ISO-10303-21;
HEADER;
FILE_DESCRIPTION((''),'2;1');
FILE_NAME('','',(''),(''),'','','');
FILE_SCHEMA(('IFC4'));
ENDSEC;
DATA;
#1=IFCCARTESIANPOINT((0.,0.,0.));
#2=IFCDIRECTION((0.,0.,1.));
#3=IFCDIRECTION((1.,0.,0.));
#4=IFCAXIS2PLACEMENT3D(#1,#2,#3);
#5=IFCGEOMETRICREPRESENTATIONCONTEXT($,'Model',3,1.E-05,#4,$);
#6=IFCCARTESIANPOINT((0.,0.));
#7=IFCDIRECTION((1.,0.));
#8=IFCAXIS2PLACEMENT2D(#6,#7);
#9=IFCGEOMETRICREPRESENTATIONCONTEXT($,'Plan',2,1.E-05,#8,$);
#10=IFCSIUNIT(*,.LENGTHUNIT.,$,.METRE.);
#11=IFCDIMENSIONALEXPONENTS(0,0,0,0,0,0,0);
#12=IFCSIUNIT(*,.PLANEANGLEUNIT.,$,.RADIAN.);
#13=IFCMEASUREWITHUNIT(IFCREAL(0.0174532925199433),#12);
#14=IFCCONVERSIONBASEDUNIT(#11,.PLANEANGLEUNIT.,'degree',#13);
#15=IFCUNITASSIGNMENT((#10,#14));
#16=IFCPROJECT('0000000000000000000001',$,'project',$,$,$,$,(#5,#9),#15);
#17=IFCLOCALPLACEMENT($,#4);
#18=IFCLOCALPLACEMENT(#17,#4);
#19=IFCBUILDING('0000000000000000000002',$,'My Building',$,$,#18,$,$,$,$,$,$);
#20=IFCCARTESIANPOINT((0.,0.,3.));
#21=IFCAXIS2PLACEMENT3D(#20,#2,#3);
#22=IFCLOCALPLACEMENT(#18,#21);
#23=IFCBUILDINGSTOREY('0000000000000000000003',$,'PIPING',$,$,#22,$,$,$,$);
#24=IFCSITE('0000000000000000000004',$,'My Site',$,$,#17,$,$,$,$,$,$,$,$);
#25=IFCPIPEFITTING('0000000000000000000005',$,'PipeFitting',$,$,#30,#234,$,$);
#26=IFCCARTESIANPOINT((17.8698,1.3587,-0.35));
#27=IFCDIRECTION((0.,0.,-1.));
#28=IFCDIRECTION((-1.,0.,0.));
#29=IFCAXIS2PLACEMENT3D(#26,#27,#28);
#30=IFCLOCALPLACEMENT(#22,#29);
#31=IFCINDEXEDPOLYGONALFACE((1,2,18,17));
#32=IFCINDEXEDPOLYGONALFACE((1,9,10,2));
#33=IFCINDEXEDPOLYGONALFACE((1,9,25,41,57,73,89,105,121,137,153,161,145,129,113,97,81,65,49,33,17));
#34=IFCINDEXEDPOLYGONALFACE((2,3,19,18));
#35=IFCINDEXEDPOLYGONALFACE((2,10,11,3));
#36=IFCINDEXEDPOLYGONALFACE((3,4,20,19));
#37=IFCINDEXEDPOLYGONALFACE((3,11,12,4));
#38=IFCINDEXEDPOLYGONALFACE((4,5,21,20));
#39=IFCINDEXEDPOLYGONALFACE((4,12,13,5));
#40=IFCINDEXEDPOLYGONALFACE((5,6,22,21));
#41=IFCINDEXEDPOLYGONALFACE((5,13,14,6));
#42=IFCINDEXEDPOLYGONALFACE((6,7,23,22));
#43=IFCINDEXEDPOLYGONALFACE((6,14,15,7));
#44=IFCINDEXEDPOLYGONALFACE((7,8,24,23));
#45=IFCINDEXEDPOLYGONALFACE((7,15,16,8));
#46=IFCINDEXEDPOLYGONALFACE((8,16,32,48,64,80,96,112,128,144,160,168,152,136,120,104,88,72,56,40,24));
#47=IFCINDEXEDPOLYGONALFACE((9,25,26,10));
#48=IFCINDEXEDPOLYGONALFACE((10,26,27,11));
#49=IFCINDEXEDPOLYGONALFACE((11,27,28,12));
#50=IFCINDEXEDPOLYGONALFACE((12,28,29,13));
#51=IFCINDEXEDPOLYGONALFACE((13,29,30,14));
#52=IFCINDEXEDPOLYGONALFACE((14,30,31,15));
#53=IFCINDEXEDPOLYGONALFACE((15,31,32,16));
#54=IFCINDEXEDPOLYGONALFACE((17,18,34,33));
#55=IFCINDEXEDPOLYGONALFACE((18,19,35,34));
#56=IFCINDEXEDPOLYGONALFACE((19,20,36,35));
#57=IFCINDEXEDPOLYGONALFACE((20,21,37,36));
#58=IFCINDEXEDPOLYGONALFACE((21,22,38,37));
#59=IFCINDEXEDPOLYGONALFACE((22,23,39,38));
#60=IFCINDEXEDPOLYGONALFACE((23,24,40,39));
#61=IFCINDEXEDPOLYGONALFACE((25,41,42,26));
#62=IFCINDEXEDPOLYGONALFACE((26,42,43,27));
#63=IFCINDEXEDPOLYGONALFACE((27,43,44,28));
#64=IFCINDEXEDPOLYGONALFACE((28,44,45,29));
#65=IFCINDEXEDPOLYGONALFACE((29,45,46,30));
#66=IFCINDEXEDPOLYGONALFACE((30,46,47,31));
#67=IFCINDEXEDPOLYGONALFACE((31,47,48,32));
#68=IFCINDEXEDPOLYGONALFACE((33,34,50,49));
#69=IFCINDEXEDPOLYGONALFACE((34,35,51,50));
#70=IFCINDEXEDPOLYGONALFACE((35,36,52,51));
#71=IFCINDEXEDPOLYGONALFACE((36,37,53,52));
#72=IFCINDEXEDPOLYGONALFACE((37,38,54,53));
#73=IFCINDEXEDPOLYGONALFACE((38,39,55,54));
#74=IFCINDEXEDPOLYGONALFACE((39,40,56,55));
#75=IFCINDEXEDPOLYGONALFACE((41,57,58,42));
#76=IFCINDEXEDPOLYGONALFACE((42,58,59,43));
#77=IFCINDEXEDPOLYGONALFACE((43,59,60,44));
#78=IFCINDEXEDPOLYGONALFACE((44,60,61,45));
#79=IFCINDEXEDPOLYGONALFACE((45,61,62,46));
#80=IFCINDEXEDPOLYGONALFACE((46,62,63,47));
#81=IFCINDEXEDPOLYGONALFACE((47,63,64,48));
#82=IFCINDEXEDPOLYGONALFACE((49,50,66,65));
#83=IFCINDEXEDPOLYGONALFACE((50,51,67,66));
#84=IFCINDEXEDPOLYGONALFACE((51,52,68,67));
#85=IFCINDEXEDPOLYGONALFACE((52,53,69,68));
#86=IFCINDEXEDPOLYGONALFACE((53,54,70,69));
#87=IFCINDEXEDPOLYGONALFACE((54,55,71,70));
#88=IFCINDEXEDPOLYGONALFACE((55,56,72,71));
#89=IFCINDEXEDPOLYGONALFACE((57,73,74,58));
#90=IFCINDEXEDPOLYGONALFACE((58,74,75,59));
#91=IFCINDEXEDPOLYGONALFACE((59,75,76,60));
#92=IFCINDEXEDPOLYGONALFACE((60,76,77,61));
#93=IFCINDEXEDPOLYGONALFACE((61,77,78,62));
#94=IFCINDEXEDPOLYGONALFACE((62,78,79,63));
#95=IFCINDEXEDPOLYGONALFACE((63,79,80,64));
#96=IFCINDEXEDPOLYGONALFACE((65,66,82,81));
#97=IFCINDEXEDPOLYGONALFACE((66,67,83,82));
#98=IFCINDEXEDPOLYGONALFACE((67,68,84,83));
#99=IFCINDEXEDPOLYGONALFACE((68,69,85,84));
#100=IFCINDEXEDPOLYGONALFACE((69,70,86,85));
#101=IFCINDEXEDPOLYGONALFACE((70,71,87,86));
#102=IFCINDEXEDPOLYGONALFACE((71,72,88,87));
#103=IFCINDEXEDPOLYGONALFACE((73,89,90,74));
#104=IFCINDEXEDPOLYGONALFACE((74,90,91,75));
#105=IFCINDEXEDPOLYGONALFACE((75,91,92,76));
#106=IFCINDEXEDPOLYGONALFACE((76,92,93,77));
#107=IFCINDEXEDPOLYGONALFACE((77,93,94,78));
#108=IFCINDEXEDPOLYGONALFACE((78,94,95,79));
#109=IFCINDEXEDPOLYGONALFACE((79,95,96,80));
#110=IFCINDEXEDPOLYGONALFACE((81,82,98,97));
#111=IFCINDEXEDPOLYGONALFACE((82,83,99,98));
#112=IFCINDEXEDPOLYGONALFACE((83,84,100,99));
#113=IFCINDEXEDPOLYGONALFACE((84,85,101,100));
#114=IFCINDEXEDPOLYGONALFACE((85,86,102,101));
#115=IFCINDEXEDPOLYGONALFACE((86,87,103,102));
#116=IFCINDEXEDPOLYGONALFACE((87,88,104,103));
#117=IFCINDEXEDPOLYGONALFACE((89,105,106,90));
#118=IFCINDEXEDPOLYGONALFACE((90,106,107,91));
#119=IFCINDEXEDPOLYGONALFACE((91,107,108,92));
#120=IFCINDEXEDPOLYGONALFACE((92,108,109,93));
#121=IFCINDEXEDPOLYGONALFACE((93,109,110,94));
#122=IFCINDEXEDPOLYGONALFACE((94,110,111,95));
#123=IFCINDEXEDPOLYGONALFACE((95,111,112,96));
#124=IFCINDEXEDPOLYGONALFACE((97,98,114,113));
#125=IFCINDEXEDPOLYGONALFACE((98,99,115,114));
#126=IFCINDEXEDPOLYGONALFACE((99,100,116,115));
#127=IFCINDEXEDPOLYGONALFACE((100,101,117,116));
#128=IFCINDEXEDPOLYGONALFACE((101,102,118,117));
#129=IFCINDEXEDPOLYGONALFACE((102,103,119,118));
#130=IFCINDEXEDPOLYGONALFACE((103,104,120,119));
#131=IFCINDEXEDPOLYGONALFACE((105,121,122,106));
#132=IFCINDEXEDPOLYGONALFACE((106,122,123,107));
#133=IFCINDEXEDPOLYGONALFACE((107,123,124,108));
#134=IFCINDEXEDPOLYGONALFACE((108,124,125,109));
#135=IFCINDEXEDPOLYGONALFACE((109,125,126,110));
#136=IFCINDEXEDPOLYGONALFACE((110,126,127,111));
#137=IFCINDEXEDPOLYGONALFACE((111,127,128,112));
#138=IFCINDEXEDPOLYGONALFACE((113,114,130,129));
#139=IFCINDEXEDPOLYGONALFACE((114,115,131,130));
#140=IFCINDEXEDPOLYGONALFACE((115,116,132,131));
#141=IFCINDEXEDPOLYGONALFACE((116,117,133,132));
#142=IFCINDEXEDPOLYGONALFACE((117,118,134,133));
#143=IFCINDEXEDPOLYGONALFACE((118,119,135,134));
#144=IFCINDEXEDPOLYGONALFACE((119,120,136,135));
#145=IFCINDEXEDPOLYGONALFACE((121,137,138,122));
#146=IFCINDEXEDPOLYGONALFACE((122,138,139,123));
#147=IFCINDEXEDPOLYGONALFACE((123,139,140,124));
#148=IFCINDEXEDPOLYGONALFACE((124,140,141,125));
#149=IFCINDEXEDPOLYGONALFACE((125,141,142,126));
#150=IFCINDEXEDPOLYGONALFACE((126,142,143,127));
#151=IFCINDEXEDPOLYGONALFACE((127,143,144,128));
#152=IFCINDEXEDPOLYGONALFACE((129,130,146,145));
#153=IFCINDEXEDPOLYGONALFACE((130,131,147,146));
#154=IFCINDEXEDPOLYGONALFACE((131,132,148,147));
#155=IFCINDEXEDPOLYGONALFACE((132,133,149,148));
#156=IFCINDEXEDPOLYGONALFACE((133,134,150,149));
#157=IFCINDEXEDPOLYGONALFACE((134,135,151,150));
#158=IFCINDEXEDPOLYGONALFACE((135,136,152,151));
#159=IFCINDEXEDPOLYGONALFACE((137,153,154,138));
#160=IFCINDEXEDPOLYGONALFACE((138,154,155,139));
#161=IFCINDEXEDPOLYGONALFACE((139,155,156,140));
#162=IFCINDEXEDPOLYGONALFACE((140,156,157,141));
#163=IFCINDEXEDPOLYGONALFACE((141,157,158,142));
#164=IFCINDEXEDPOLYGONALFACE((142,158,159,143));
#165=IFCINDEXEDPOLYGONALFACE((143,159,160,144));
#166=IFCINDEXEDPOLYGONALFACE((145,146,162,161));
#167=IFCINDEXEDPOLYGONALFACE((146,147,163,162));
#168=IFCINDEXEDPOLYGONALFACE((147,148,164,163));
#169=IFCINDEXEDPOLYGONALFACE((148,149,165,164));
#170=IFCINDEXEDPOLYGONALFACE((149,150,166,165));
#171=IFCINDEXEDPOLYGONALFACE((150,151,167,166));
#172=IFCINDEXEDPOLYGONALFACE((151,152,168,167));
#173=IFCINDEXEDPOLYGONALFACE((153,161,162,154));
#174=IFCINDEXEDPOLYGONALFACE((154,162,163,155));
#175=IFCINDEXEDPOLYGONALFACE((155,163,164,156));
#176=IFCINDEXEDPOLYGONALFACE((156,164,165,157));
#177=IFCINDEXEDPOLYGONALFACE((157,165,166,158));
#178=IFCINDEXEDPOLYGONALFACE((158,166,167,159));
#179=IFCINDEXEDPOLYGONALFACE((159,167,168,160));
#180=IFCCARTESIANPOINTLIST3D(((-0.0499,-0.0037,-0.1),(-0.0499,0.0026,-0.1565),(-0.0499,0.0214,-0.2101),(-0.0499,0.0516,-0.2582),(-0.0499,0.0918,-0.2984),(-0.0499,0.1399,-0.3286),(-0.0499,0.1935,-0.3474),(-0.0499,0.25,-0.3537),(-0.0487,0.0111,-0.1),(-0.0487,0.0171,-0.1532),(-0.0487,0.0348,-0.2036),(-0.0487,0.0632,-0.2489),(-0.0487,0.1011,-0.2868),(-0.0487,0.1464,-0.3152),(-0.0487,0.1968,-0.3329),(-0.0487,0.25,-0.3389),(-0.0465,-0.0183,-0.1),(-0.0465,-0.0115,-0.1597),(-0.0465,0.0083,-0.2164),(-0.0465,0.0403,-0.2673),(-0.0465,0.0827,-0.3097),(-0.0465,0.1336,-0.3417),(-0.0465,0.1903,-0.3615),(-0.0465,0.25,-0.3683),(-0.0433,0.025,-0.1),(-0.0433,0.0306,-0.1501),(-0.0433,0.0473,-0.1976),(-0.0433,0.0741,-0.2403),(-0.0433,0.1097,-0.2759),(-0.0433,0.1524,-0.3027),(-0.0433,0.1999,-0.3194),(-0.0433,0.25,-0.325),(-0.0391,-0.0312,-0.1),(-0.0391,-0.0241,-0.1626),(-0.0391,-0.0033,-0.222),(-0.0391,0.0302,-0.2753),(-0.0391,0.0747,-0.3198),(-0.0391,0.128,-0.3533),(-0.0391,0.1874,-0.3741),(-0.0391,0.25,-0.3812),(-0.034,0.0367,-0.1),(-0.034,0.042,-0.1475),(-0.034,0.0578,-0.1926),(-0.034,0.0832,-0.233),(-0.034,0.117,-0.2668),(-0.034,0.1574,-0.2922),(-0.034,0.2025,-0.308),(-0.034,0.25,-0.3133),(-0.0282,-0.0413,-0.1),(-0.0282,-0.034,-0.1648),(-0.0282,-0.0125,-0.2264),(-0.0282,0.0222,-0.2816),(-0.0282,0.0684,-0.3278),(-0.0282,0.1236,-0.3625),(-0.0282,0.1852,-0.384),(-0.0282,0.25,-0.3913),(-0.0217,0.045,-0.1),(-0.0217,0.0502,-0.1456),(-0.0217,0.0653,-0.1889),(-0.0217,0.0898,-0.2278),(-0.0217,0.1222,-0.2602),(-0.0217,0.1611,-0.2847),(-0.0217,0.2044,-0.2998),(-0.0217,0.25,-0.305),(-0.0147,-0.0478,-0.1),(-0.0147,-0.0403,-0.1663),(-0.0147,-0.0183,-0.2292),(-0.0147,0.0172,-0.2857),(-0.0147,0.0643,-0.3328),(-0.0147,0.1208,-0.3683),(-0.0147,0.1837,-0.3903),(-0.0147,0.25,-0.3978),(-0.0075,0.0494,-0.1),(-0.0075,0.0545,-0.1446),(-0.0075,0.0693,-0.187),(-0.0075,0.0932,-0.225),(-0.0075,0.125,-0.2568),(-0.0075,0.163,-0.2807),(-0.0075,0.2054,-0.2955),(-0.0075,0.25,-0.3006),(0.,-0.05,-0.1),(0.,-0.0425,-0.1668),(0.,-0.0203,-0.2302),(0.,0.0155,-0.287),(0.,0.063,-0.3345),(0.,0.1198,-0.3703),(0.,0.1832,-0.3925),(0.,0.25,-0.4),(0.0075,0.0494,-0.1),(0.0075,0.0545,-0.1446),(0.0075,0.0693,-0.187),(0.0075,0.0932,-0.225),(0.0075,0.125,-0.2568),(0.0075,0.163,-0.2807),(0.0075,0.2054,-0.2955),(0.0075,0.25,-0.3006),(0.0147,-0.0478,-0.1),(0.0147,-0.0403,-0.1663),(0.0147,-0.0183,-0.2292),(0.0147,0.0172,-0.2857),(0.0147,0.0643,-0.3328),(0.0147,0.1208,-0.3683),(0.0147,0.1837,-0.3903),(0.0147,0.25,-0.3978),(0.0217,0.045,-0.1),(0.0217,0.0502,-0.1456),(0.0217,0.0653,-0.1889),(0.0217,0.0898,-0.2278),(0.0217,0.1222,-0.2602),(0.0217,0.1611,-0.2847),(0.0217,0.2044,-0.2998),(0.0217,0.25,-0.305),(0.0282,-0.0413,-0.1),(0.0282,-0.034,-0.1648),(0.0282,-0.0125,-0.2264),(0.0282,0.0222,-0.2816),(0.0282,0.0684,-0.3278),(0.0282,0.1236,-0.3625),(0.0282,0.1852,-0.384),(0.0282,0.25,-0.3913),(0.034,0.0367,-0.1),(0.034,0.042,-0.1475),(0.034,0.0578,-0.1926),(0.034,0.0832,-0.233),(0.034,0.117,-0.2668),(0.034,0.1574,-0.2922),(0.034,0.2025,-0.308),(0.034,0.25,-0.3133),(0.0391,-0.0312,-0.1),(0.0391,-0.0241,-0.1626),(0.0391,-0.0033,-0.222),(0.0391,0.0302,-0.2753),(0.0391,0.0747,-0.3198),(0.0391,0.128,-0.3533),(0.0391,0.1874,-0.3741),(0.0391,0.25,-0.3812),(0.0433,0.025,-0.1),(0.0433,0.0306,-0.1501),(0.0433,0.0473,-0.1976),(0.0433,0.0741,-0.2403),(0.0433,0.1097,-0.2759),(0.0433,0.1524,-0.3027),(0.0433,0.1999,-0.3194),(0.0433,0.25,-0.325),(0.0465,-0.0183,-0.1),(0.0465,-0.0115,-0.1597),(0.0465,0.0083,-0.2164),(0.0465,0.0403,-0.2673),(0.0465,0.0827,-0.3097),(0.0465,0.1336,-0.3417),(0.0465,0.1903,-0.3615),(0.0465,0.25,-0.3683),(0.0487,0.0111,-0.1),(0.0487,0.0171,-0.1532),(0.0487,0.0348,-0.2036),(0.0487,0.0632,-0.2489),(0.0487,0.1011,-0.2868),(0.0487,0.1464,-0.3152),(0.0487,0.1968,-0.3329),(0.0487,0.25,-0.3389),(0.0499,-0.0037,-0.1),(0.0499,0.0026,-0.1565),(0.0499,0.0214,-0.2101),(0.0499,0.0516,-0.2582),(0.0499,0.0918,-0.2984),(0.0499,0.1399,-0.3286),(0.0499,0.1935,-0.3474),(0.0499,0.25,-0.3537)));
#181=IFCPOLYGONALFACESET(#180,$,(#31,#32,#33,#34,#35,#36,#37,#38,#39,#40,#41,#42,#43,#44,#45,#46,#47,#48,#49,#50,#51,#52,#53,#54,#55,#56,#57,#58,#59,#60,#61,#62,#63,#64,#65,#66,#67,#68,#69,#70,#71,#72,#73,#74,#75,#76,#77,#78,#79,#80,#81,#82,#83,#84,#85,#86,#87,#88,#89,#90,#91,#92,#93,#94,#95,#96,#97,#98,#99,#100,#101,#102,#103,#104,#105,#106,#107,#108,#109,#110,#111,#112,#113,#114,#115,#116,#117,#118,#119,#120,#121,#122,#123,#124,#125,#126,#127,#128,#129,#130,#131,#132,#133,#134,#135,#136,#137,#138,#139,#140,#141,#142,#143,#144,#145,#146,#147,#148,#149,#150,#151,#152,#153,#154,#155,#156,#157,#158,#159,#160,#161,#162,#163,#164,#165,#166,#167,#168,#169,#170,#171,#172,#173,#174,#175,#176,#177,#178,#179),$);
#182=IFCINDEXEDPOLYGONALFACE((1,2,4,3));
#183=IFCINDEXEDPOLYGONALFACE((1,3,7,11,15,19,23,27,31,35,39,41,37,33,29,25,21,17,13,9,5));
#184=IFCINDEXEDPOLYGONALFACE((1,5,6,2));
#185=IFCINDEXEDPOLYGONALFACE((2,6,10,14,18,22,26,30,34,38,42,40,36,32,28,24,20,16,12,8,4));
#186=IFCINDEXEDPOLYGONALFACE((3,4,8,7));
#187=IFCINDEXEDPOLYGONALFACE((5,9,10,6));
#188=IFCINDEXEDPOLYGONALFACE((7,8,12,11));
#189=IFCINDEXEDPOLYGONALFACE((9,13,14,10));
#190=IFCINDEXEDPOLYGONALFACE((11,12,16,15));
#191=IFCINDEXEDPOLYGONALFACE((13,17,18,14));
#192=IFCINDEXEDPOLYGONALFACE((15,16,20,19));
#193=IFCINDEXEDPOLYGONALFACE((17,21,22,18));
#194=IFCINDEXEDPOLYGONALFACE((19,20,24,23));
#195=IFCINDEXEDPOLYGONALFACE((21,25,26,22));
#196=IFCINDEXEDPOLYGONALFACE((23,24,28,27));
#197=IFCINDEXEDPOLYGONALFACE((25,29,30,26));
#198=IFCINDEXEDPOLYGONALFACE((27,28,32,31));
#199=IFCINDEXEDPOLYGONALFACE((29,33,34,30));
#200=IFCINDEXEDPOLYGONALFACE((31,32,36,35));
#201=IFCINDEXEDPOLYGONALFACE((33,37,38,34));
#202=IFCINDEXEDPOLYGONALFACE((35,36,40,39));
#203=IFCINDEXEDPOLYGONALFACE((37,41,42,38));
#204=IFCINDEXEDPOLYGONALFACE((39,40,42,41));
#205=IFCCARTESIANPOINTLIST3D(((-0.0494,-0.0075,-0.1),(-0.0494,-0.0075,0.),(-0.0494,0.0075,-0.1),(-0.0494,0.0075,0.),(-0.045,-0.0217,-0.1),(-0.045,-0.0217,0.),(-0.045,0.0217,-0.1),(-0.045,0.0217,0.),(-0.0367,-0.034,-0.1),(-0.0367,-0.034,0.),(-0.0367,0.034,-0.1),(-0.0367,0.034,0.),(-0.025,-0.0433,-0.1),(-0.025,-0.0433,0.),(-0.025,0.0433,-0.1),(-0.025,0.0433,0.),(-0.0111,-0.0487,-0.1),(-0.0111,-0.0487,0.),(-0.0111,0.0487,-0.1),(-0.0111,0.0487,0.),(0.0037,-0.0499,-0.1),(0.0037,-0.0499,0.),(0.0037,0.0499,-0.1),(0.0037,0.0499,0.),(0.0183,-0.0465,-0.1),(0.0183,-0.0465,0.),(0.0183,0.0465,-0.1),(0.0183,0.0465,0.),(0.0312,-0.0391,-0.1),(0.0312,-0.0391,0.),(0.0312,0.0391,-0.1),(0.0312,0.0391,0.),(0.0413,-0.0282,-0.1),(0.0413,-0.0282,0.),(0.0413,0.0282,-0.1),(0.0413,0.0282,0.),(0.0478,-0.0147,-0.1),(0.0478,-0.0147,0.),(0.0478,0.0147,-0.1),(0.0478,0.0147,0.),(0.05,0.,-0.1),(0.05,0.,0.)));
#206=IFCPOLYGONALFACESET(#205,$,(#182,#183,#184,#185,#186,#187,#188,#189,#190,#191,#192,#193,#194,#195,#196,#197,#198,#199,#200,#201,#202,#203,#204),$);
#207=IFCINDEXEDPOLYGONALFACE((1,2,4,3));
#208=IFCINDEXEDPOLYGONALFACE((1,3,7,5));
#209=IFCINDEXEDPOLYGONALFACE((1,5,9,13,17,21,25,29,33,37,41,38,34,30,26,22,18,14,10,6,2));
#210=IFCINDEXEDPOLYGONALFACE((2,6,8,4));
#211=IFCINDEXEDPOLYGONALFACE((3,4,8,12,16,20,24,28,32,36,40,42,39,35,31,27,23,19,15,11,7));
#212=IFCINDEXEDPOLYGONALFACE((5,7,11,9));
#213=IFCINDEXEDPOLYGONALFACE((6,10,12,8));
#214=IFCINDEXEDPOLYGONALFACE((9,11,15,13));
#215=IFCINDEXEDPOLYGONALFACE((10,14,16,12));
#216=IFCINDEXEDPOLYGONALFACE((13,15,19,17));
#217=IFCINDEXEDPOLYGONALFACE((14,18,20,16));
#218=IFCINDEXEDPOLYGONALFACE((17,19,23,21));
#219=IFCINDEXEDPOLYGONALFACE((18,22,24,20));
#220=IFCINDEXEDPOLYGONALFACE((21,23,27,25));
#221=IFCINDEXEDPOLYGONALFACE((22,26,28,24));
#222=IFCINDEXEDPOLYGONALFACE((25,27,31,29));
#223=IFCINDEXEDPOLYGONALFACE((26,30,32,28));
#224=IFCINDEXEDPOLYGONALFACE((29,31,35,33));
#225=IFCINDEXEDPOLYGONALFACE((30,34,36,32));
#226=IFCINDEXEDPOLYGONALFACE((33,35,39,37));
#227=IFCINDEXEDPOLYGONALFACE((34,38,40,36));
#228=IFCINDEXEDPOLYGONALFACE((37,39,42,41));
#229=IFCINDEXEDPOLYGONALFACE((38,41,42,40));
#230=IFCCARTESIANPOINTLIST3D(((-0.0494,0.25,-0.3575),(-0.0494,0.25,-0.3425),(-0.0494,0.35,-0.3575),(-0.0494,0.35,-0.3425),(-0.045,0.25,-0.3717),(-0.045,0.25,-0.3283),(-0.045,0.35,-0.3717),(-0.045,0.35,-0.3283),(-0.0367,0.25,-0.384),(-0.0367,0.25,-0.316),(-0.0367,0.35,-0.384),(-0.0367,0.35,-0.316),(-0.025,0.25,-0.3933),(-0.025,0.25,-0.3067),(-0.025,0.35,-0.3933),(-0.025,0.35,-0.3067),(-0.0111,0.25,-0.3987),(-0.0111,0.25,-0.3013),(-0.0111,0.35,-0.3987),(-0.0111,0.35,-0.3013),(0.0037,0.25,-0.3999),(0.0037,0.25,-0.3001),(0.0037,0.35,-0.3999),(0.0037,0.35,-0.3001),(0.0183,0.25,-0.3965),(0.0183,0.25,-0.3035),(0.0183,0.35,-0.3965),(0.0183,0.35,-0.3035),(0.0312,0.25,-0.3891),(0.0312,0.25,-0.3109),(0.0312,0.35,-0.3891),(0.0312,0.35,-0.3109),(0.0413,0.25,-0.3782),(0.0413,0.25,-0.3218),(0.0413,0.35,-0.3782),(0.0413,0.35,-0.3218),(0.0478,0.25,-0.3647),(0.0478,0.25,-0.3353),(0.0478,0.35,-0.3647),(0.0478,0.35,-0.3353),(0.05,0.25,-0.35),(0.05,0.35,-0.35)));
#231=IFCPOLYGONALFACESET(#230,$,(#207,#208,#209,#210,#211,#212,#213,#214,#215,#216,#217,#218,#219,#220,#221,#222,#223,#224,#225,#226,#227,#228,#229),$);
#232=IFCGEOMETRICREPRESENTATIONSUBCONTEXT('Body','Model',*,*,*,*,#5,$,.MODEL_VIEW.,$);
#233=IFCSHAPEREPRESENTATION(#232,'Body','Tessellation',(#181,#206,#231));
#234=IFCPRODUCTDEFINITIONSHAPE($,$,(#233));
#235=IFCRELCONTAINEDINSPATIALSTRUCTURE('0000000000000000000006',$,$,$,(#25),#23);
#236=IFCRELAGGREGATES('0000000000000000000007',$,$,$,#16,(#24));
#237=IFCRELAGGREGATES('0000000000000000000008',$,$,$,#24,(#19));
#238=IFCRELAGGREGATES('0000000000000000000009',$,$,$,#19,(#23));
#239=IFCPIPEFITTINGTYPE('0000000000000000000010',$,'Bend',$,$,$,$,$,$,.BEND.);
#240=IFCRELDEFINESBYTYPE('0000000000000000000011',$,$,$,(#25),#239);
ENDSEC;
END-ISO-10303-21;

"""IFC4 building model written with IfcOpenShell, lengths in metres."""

from ifc_helpers import new_model, entity, si_unit, converted_unit, frame, origin_with_axes, origin_2d_with_axis, place, context, subcontext, project, spatial, line, indexed_curve, circle, outline, extrude, source, transform, mapped, type_object, type_shapes, element, save


model = new_model("IFC4")

# Units and contexts
model_context = context("Model", 3, precision=1e-05, world=origin_with_axes())
plan_context = context("Plan", 2, precision=1e-05, world=origin_2d_with_axis())
body_context = subcontext(model_context, "Body", "Model", "MODEL_VIEW")
ifc_project = project(units=[si_unit("LENGTHUNIT", "METRE"), converted_unit("PLANEANGLEUNIT", "degree", entity("IfcReal", 0.0174532925199433), si_unit("PLANEANGLEUNIT", "RADIAN"), dimensions=[0, 0, 0, 0, 0, 0, 0])], contexts=[model_context, plan_context])

# Site, building, storey
site_placement = place(None, origin_with_axes())
site = spatial("IfcSite", under=ifc_project, at=site_placement, Name="My Site")
building_placement = place(site_placement, origin_with_axes())
building = spatial("IfcBuilding", under=site, at=building_placement, Name="My Building")
storey_placement = place(building_placement, frame((0.0, 0.0, 3.0), z_axis=(0.0, 0.0, 1.0), x_axis=(1.0, 0.0, 0.0)))
storey = spatial("IfcBuildingStorey", under=building, at=storey_placement, Name="PIPING")

# Shared definitions
pipe_fitting_type = type_object("IfcPipeFittingType", Name="Bend", PredefinedType="BEND")
shared_shape = source(origin_with_axes(), body_context, "Body", "SolidModel", [
    entity("IfcSweptDiskSolid", entity("IfcIndexedPolyCurve", entity("IfcCartesianPointList3D", [[0.0, 0.0, -0.1], [0.0, 0.0732, -0.2768], [0.0, 0.25, -0.35]]), [entity("IfcArcIndex", [1, 2, 3])]), 0.05),
    extrude(circle(Radius=0.05), origin_with_axes(), (0.0, 0.0, -1.0), 0.1),
    extrude(circle(Radius=0.05), frame((0.0, 0.25, -0.35), z_axis=(0.0, 1.0, 0.0), x_axis=(1.0, 0.0, 0.0)), (0.0, 0.0, 1.0), 0.1),
])
type_shapes(pipe_fitting_type, [shared_shape])

# Pipe fitting, opening
pipe_fitting_1_placement = place(storey_placement, frame((17.8698, 1.3587, -0.35), z_axis=(0.0, 0.0, -1.0), x_axis=(-1.0, 0.0, 0.0)))
pipe_fitting_1 = element("IfcPipeFitting", 1, at=pipe_fitting_1_placement, inside=storey, type_object=pipe_fitting_type, Name="PipeFitting", context=body_context, shape_type="MappedRepresentation", body=[
    mapped(shared_shape, transform((0.0, 0.0, 0.0), x_axis=(1.0, 0.0, 0.0), y_axis=(0.0, 1.0, 0.0), z_axis=(0.0, 0.0, 1.0), scale=1.0)),
])
opening_1_placement = place(pipe_fitting_1_placement, frame((1.768, -1.3587, 2.65), z_axis=(0.0, 0.0, -1.0), x_axis=(-1.0, 0.0, 0.0)))
element("IfcOpeningElement", 2, at=opening_1_placement, cuts=pipe_fitting_1, PredefinedType="OPENING", context=body_context, shape_type="SweptSolid", body=[
    extrude(outline(indexed_curve([(0.0, 0.0), (0.5, 0.0), (0.5, 0.5), (0.0, 0.5)], segments=[line(1, 2, 3, 4, 1)])), origin_with_axes(), (0.0, 0.0, 1.0), 0.5),
])

save(model, "model.ifc")
